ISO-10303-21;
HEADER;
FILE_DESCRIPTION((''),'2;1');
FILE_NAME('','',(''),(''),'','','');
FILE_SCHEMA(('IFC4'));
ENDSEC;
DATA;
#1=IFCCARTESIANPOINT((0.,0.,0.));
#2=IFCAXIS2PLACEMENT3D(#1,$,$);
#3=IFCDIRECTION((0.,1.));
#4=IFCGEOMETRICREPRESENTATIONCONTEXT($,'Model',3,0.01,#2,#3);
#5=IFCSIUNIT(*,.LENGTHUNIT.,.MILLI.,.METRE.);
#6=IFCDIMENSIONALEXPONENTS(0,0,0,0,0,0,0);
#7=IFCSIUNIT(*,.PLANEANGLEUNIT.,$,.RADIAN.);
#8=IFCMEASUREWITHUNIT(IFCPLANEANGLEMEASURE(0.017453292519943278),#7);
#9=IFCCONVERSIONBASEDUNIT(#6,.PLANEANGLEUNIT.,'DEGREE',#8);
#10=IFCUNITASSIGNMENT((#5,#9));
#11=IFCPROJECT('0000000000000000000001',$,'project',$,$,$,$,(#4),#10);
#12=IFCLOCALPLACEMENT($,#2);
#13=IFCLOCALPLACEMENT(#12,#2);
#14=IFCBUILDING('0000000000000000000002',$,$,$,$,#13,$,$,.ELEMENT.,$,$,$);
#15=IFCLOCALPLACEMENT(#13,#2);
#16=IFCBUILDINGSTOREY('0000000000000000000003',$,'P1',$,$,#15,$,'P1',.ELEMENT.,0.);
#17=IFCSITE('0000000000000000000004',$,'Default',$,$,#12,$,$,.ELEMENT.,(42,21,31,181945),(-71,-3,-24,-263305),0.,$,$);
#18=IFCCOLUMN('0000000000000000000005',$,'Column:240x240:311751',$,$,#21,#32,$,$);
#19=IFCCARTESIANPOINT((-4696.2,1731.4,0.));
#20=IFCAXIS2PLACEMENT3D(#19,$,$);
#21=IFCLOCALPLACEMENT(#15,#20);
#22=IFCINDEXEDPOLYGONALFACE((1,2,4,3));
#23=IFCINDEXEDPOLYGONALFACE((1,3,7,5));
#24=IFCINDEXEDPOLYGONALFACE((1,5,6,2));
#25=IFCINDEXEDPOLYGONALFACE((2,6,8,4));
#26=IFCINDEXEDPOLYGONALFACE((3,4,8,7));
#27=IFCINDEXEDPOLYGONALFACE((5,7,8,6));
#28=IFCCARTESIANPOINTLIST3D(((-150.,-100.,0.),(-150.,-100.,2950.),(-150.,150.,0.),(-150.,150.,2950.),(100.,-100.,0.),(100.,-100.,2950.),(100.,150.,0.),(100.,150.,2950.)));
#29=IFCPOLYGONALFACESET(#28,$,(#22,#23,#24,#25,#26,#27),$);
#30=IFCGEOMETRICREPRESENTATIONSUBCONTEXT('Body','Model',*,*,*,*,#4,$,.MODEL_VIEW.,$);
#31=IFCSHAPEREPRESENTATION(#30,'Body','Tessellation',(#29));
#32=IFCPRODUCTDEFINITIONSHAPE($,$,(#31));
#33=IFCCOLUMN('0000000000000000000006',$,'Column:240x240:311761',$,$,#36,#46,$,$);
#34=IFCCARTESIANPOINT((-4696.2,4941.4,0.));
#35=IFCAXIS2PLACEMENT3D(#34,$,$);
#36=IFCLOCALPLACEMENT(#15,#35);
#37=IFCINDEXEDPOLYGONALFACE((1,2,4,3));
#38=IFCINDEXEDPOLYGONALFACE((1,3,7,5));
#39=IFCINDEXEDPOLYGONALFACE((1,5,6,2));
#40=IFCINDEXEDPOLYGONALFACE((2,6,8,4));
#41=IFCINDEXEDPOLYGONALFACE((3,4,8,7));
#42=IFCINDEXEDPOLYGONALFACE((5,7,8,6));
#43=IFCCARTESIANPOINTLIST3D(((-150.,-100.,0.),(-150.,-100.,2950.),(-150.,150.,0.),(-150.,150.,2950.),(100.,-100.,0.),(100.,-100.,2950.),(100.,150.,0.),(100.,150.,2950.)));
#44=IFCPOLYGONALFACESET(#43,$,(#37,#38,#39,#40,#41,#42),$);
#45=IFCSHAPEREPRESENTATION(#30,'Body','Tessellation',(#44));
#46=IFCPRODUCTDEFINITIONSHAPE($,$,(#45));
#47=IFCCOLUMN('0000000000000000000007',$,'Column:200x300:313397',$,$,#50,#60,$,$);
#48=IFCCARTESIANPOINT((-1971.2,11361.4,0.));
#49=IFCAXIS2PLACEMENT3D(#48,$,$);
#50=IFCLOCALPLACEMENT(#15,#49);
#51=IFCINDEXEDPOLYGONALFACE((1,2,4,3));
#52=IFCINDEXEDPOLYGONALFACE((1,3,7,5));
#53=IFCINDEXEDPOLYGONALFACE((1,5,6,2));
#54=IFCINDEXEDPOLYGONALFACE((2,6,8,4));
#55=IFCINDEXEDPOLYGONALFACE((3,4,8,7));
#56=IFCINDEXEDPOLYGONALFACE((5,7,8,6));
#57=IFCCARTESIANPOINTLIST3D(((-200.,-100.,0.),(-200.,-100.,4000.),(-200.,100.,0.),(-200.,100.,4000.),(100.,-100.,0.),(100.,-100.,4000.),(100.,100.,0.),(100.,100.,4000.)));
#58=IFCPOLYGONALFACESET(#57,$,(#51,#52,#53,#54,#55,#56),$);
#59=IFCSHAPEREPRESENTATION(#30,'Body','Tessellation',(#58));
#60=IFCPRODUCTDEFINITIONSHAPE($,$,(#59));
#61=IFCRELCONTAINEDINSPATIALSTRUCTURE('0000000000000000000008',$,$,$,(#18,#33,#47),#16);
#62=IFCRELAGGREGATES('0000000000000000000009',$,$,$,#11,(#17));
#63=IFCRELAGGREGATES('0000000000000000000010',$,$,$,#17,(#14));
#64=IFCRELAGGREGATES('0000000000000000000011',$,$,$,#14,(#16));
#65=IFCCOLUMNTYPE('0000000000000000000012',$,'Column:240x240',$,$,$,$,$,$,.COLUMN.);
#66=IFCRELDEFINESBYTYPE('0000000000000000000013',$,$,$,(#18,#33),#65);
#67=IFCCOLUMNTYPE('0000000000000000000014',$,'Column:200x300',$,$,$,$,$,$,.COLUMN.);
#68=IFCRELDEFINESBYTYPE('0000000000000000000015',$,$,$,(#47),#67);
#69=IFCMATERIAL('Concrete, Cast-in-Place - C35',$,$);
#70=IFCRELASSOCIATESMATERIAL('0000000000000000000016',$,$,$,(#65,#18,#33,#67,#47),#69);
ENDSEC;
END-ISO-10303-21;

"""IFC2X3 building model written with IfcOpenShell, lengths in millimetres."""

from ifc_helpers import new_model, entity, si_unit, converted_unit, direction, frame, origin, origin_2d_with_axis, place, context, subcontext, project, spatial, rectangle, extrude, source, transform, mapped, material, type_object, type_shapes, element, save


model = new_model("IFC2X3")

# Units and contexts
model_context = context("Model", 3, precision=0.01, world=origin(), true_north=direction((0.0, 1.0)))
body_context = subcontext(model_context, "Body", "Model", "MODEL_VIEW")
ifc_project = project(units=[si_unit("LENGTHUNIT", "METRE", prefix="MILLI"), converted_unit("PLANEANGLEUNIT", "DEGREE", entity("IfcPlaneAngleMeasure", 0.017453292519943278), si_unit("PLANEANGLEUNIT", "RADIAN"), dimensions=[0, 0, 0, 0, 0, 0, 0])], contexts=[model_context])

# Site, building, storey
site_placement = place(None, origin())
site = spatial("IfcSite", under=ifc_project, at=site_placement, Name="Default", CompositionType="ELEMENT", RefLatitude=(42, 21, 31, 181945), RefLongitude=(-71, -3, -24, -263305), RefElevation=0.0)
building_placement = place(site_placement, origin())
building = spatial("IfcBuilding", under=site, at=building_placement, CompositionType="ELEMENT")
storey_placement = place(building_placement, origin())
storey = spatial("IfcBuildingStorey", under=building, at=storey_placement, Name="P1", LongName="P1", CompositionType="ELEMENT", Elevation=0.0)

# Columns
ifc_material_1 = material(Name="Concrete, Cast-in-Place - C35")
column_type_1 = type_object("IfcColumnType", Name="Column:240x240", PredefinedType="COLUMN", material=ifc_material_1)
shared_shape_1 = source(origin(), body_context, "Body", "SweptSolid", [
    extrude(rectangle(XDim=250.0, YDim=250.0, at=origin_2d_with_axis()), frame((-25.0, 25.0, 0.0), z_axis=(0.0, 0.0, 1.0), x_axis=(-1.0, 0.0, 0.0)), (0.0, 0.0, 1.0), 2950.0),
])
type_shapes(column_type_1, [shared_shape_1])
for number, where, name in (
    (1, (-4696.2, 1731.4, 0.0), "Column:240x240:311751"),
    (2, (-4696.2, 4941.4, 0.0), "Column:240x240:311761"),
):
    element("IfcColumn", number, at=place(storey_placement, frame(where)), inside=storey, type_object=column_type_1, material=ifc_material_1, Name=name, context=body_context, shape_type="MappedRepresentation", body=[
        mapped(shared_shape_1, transform((0.0, 0.0, 0.0), scale=1.0)),
    ])
column_type_2 = type_object("IfcColumnType", Name="Column:200x300", PredefinedType="COLUMN", material=ifc_material_1)
shared_shape_2 = source(origin(), body_context, "Body", "SweptSolid", [
    extrude(rectangle(XDim=300.0, YDim=200.0, at=origin_2d_with_axis()), frame((-50.0, 0.0, 0.0), z_axis=(0.0, 0.0, 1.0), x_axis=(-1.0, 0.0, 0.0)), (0.0, 0.0, 1.0), 4000.0),
])
type_shapes(column_type_2, [shared_shape_2])
column_1_placement = place(storey_placement, frame((-1971.2, 11361.4, 0.0)))
element("IfcColumn", 3, at=column_1_placement, inside=storey, type_object=column_type_2, material=ifc_material_1, Name="Column:200x300:313397", context=body_context, shape_type="MappedRepresentation", body=[
    mapped(shared_shape_2, transform((0.0, 0.0, 0.0), scale=1.0)),
])

save(model, "model.ifc")
